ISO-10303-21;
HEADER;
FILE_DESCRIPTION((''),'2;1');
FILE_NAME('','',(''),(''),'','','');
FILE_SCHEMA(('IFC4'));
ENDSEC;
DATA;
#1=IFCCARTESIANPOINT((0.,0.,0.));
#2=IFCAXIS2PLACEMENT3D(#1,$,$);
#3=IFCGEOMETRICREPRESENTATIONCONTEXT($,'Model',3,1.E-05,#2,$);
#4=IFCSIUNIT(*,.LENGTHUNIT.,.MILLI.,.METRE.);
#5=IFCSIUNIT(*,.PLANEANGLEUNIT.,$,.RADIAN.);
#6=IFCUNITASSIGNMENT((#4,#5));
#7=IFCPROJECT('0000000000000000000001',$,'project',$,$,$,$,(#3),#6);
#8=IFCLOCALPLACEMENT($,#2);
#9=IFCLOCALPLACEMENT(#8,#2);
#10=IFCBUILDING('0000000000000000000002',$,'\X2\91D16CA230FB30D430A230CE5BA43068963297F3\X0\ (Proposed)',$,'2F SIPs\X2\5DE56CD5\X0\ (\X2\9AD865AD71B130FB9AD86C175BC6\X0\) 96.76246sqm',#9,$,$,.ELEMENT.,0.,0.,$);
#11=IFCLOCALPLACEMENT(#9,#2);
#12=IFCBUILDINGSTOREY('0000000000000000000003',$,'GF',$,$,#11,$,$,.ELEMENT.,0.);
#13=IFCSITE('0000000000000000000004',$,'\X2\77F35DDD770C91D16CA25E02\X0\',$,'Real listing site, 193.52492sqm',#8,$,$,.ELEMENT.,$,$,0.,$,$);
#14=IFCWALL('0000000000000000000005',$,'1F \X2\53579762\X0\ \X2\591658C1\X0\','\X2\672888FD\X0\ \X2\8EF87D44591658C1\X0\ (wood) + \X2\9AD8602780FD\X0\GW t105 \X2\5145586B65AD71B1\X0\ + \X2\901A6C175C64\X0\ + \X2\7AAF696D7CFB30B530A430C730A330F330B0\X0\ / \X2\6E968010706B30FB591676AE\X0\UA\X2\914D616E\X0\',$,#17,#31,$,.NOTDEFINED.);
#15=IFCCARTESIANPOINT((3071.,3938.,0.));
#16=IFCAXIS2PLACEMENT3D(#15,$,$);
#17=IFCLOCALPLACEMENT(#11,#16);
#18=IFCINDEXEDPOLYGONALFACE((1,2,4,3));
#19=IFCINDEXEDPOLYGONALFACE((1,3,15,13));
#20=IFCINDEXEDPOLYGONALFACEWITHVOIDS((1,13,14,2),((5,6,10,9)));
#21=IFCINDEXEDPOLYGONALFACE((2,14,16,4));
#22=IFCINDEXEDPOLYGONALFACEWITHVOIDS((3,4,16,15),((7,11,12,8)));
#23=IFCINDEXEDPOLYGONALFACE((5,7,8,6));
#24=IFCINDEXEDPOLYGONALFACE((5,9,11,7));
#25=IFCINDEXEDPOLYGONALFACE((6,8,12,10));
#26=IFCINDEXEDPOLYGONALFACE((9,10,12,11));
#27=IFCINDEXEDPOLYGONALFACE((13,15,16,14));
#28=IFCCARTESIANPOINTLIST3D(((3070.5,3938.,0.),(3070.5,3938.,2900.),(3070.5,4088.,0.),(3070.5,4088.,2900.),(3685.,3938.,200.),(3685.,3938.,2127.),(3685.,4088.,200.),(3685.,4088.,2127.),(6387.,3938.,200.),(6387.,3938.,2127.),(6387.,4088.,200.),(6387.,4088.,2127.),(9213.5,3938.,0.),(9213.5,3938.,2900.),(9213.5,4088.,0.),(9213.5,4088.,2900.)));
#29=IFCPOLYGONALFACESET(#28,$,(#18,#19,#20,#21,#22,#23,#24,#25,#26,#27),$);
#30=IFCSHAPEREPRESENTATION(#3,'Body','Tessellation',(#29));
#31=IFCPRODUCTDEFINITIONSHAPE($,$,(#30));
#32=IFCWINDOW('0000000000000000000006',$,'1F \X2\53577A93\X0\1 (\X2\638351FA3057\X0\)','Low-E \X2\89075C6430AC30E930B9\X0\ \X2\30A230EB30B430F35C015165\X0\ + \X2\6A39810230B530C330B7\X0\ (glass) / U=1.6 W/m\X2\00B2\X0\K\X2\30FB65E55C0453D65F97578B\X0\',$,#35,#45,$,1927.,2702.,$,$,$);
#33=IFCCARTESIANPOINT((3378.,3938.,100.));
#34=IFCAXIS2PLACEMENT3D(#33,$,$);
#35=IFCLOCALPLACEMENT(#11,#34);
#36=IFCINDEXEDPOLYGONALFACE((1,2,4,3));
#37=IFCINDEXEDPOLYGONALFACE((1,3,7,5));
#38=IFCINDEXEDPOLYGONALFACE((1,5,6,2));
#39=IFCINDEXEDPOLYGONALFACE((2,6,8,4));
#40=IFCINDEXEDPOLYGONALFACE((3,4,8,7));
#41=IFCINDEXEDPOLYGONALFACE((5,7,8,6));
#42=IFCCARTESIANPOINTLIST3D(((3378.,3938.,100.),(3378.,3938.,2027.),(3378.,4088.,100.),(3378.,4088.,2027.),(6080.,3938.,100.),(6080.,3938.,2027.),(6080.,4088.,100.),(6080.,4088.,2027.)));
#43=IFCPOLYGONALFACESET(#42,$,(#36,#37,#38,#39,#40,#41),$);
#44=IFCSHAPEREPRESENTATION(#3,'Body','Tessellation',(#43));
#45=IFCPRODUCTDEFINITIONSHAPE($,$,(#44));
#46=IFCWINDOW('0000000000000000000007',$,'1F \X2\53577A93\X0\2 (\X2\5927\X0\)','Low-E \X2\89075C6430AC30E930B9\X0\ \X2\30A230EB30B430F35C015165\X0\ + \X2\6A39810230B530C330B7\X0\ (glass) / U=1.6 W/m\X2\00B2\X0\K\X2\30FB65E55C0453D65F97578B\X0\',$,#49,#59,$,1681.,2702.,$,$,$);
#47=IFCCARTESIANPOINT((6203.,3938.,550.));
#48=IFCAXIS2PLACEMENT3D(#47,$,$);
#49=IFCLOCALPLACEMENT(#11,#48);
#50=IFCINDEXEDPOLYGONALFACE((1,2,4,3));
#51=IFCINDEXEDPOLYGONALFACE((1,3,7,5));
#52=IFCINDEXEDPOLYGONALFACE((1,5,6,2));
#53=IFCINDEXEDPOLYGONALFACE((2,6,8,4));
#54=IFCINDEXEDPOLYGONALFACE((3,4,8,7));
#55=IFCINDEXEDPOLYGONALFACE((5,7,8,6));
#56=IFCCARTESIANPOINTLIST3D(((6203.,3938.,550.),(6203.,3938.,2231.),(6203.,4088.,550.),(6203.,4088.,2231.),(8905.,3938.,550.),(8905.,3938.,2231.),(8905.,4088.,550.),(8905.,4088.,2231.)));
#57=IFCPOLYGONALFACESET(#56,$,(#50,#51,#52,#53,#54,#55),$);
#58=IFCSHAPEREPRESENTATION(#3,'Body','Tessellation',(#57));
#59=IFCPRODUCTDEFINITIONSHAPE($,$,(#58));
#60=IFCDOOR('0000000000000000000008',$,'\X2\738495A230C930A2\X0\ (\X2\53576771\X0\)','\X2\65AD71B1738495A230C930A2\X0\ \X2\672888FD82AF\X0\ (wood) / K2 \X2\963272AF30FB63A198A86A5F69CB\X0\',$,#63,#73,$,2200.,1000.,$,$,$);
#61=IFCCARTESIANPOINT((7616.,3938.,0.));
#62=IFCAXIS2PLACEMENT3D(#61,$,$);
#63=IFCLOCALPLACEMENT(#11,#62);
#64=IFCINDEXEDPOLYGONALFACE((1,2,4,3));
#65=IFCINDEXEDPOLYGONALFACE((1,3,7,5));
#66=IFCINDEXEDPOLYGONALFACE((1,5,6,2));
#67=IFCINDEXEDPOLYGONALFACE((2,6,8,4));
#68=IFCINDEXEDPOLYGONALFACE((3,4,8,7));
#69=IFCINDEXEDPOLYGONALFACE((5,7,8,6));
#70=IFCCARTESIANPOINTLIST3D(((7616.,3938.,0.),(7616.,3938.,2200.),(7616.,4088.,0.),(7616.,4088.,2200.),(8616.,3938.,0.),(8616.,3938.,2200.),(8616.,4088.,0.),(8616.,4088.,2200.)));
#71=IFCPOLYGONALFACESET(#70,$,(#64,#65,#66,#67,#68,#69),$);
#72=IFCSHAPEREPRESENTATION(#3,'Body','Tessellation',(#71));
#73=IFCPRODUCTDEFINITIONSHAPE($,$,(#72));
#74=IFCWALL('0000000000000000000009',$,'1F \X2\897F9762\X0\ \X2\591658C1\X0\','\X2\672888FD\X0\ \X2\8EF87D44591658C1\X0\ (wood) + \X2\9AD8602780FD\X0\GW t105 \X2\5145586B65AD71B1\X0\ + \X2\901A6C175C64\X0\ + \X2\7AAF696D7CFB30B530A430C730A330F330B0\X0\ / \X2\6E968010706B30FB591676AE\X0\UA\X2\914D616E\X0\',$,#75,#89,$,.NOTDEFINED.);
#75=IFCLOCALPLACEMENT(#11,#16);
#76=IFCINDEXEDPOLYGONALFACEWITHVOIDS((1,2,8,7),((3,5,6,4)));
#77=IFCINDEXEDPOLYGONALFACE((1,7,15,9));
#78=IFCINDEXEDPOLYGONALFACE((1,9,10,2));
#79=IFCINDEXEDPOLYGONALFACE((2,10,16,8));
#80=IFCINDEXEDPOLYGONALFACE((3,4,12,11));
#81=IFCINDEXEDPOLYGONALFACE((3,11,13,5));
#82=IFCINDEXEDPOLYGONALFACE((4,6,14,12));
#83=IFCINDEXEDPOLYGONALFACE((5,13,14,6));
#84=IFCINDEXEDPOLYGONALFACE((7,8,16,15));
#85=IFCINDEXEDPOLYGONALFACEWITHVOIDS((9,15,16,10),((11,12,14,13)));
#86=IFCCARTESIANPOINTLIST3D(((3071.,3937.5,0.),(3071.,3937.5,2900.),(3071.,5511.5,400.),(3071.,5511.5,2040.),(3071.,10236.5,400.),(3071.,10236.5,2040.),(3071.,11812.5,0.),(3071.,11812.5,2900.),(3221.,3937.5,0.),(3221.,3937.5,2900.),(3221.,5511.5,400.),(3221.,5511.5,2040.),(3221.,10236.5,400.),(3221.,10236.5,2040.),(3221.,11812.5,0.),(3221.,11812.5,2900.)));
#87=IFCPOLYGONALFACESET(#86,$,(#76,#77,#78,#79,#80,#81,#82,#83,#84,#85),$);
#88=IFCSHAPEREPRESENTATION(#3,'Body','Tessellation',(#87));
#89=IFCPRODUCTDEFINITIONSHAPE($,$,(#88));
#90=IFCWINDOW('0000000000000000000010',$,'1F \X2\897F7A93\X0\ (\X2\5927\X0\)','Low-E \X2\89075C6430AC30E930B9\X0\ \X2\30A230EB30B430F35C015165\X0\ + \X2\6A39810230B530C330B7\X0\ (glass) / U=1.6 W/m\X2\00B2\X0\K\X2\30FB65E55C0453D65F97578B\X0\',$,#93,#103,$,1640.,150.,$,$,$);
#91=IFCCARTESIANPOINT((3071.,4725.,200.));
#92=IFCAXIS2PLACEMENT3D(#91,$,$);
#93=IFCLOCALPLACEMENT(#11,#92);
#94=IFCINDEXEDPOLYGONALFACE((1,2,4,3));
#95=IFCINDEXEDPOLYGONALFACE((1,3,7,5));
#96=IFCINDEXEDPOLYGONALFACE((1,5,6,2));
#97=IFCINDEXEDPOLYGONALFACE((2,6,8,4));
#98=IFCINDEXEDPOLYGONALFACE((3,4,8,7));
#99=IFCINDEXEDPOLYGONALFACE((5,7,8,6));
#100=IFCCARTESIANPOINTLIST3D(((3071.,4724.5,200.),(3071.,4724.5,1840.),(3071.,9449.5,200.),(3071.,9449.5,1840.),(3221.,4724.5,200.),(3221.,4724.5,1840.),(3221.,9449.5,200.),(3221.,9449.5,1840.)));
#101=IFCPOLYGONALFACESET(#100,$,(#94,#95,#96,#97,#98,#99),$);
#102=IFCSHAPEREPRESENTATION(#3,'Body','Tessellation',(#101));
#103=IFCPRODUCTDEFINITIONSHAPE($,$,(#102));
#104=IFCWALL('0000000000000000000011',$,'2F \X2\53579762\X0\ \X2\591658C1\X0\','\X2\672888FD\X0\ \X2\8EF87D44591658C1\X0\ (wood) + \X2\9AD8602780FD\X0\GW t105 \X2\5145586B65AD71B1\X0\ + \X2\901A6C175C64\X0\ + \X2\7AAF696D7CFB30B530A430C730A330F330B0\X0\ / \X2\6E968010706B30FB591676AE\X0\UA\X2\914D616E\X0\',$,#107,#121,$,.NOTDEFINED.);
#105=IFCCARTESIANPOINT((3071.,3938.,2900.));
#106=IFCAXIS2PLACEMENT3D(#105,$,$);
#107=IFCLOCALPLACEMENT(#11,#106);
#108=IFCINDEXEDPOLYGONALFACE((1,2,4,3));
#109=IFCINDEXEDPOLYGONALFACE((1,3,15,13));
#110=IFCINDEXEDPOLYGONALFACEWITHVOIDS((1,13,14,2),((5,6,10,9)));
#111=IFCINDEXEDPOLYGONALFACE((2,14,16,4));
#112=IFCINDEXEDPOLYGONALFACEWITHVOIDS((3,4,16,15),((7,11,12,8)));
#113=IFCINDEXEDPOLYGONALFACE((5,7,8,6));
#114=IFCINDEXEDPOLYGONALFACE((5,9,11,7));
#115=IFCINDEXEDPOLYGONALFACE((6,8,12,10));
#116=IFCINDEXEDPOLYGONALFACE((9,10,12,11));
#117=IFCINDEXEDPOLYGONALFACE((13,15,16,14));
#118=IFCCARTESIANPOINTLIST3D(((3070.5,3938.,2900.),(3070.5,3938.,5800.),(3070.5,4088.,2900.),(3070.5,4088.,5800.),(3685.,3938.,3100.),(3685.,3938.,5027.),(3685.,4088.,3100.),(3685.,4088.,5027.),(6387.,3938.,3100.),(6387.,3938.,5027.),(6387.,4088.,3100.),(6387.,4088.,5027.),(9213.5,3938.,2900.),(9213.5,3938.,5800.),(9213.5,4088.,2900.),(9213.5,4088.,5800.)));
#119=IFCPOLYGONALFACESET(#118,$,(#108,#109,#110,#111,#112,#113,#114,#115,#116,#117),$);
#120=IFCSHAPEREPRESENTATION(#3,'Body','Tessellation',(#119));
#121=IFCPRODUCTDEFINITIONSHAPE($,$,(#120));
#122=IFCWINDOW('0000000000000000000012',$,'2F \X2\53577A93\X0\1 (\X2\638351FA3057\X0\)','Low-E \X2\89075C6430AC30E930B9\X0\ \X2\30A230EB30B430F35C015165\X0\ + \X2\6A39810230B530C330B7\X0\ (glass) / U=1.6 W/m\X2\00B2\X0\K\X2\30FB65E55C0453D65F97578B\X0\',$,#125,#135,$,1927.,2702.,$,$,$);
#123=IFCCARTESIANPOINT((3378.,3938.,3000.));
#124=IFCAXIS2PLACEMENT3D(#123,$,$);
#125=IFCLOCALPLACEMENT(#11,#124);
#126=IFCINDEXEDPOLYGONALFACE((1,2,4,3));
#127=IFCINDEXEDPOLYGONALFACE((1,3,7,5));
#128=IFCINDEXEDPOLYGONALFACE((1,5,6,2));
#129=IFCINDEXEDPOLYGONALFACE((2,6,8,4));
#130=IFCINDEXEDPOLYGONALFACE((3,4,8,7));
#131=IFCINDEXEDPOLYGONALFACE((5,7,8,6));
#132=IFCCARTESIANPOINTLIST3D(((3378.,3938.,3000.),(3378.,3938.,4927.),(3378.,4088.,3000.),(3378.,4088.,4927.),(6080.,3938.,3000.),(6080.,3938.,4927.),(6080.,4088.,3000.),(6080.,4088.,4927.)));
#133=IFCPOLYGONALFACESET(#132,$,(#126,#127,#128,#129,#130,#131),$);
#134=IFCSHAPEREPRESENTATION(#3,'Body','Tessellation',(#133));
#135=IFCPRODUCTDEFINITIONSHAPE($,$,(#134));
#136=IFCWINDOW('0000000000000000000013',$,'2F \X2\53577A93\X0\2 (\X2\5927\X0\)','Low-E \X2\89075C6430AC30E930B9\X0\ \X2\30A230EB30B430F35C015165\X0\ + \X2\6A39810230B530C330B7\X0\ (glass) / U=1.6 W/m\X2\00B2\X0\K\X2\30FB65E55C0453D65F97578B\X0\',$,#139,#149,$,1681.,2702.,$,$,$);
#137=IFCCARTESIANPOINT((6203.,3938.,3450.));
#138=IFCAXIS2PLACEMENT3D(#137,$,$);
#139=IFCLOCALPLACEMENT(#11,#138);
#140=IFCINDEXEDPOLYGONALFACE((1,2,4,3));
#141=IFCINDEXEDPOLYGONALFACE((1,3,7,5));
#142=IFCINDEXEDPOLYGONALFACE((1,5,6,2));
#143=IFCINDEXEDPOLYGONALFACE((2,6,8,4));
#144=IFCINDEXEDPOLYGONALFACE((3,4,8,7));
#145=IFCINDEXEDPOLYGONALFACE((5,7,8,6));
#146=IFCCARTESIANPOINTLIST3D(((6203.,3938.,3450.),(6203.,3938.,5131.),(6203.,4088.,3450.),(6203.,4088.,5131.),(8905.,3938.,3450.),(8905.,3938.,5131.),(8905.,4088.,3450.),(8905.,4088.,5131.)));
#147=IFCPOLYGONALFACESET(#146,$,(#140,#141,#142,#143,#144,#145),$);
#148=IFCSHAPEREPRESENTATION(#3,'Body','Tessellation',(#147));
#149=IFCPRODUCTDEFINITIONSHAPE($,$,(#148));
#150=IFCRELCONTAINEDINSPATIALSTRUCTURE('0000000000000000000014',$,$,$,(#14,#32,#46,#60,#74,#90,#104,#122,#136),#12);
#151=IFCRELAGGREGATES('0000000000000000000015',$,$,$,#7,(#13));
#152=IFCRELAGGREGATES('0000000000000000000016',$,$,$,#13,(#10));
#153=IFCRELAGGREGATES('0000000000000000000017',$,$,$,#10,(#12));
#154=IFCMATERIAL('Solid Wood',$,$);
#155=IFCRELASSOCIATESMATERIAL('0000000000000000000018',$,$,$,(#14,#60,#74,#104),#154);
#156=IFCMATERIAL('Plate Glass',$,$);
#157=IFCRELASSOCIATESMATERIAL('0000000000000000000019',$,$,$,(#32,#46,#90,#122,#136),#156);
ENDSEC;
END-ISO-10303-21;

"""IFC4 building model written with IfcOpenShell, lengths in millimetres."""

from ifc_helpers import new_model, si_unit, frame, frame_2d, origin, place, context, project, spatial, rectangle, extrude, material, element, fill, save


model = new_model("IFC4")

# Units and contexts
model_context = context("Model", 3, precision=1e-05, world=origin())
ifc_project = project(units=[si_unit("LENGTHUNIT", "METRE", prefix="MILLI"), si_unit("PLANEANGLEUNIT", "RADIAN")], contexts=[model_context])

# Site, building, storey
site_placement = place(None, origin())
site = spatial("IfcSite", under=ifc_project, at=site_placement, Name="石川県金沢市", ObjectType="Real listing site, 193.52492sqm", CompositionType="ELEMENT", RefElevation=0.0)
building_placement = place(site_placement, origin())
building = spatial("IfcBuilding", under=site, at=building_placement, Name="金沢・ピアノ室と防音 (Proposed)", ObjectType="2F SIPs工法 (高断熱・高気密) 96.76246sqm", CompositionType="ELEMENT", ElevationOfRefHeight=0.0, ElevationOfTerrain=0.0)
storey_placement = place(building_placement, origin())
storey = spatial("IfcBuildingStorey", under=building, at=storey_placement, Name="GF", CompositionType="ELEMENT", Elevation=0.0)

# Shared definitions
ifc_material_1 = material(Name="Solid Wood")

# Wall, openings, windows, door
wall_1_placement = place(storey_placement, frame((3071.0, 3938.0, 0.0)))
wall_1 = element("IfcWall", 1, at=wall_1_placement, inside=storey, material=ifc_material_1, Name="1F 南面 外壁", Description="木製 軸組外壁 (wood) + 高性能GW t105 充填断熱 + 通気層 + 窯業系サイディング / 準耐火・外皮UA配慮", PredefinedType="NOTDEFINED", context=model_context, shape_type="SweptSolid", body=[
    extrude(rectangle(XDim=6143.0, YDim=150.0, at=frame_2d((3071.0, 75.0))), frame((3071.0, 3938.0, 0.0)), (0.0, 0.0, 1.0), 2900.0),
])
opening_1_placement = place(storey_placement, frame((3378.0, 3938.0, 100.0)))
opening_1 = element("IfcOpeningElement", 2, at=opening_1_placement, cuts=wall_1, PredefinedType="NOTDEFINED", context=model_context, shape_type="SweptSolid", body=[
    extrude(rectangle(XDim=2702.0, YDim=150.0, at=frame_2d((1351.0, 75.0))), frame((3378.0, 3938.0, 100.0)), (0.0, 0.0, 1.0), 1927.0),
])
opening_2_placement = place(storey_placement, frame((6203.0, 3938.0, 550.0)))
opening_2 = element("IfcOpeningElement", 3, at=opening_2_placement, cuts=wall_1, PredefinedType="NOTDEFINED", context=model_context, shape_type="SweptSolid", body=[
    extrude(rectangle(XDim=2702.0, YDim=150.0, at=frame_2d((1351.0, 75.0))), frame((6203.0, 3938.0, 550.0)), (0.0, 0.0, 1.0), 1681.0),
])
opening_3_placement = place(storey_placement, frame((7616.0, 3938.0, 0.0)))
opening_3 = element("IfcOpeningElement", 4, at=opening_3_placement, cuts=wall_1, PredefinedType="NOTDEFINED", context=model_context, shape_type="SweptSolid", body=[
    extrude(rectangle(XDim=1000.0, YDim=150.0, at=frame_2d((500.0, 75.0))), frame((7616.0, 3938.0, 0.0)), (0.0, 0.0, 1.0), 2200.0),
])
ifc_material_2 = material(Name="Plate Glass")
window_1_placement = place(storey_placement, frame((3378.0, 3938.0, 100.0)))
window_1 = element("IfcWindow", 5, at=window_1_placement, inside=storey, material=ifc_material_2, Name="1F 南窓1 (掃出し)", Description="Low-E 複層ガラス アルゴン封入 + 樹脂サッシ (glass) / U=1.6 W/m²K・日射取得型", OverallHeight=1927.0, OverallWidth=2702.0, context=model_context, shape_type="SweptSolid", body=[
    extrude(rectangle(XDim=2702.0, YDim=150.0, at=frame_2d((1351.0, 75.0))), frame((3378.0, 3938.0, 100.0)), (0.0, 0.0, 1.0), 1927.0),
])
fill(opening_1, window_1)
window_2_placement = place(storey_placement, frame((6203.0, 3938.0, 550.0)))
window_2 = element("IfcWindow", 6, at=window_2_placement, inside=storey, material=ifc_material_2, Name="1F 南窓2 (大)", Description="Low-E 複層ガラス アルゴン封入 + 樹脂サッシ (glass) / U=1.6 W/m²K・日射取得型", OverallHeight=1681.0, OverallWidth=2702.0, context=model_context, shape_type="SweptSolid", body=[
    extrude(rectangle(XDim=2702.0, YDim=150.0, at=frame_2d((1351.0, 75.0))), frame((6203.0, 3938.0, 550.0)), (0.0, 0.0, 1.0), 1681.0),
])
fill(opening_2, window_2)
door_placement = place(storey_placement, frame((7616.0, 3938.0, 0.0)))
door = element("IfcDoor", 7, at=door_placement, inside=storey, material=ifc_material_1, Name="玄関ドア (南東)", Description="断熱玄関ドア 木製芯 (wood) / K2 防犯・採風機構", OverallHeight=2200.0, OverallWidth=1000.0, context=model_context, shape_type="SweptSolid", body=[
    extrude(rectangle(XDim=1000.0, YDim=150.0, at=frame_2d((500.0, 75.0))), frame((7616.0, 3938.0, 0.0)), (0.0, 0.0, 1.0), 2200.0),
])
fill(opening_3, door)

# Wall, opening, window
wall_2_placement = place(storey_placement, frame((3071.0, 3938.0, 0.0)))
wall_2 = element("IfcWall", 8, at=wall_2_placement, inside=storey, material=ifc_material_1, Name="1F 西面 外壁", Description="木製 軸組外壁 (wood) + 高性能GW t105 充填断熱 + 通気層 + 窯業系サイディング / 準耐火・外皮UA配慮", PredefinedType="NOTDEFINED", context=model_context, shape_type="SweptSolid", body=[
    extrude(rectangle(XDim=150.0, YDim=7875.0, at=frame_2d((75.0, 3937.0))), frame((3071.0, 3938.0, 0.0)), (0.0, 0.0, 1.0), 2900.0),
])
opening_4_placement = place(storey_placement, frame((3071.0, 4725.0, 200.0)))
opening_4 = element("IfcOpeningElement", 9, at=opening_4_placement, cuts=wall_2, PredefinedType="NOTDEFINED", context=model_context, shape_type="SweptSolid", body=[
    extrude(rectangle(XDim=150.0, YDim=4725.0, at=frame_2d((75.0, 2362.0))), frame((3071.0, 4725.0, 200.0)), (0.0, 0.0, 1.0), 1640.0),
])
window_3_placement = place(storey_placement, frame((3071.0, 4725.0, 200.0)))
window_3 = element("IfcWindow", 10, at=window_3_placement, inside=storey, material=ifc_material_2, Name="1F 西窓 (大)", Description="Low-E 複層ガラス アルゴン封入 + 樹脂サッシ (glass) / U=1.6 W/m²K・日射取得型", OverallHeight=1640.0, OverallWidth=150.0, context=model_context, shape_type="SweptSolid", body=[
    extrude(rectangle(XDim=150.0, YDim=4725.0, at=frame_2d((75.0, 2362.0))), frame((3071.0, 4725.0, 200.0)), (0.0, 0.0, 1.0), 1640.0),
])
fill(opening_4, window_3)

# Wall, openings, windows
wall_3_placement = place(storey_placement, frame((3071.0, 3938.0, 2900.0)))
wall_3 = element("IfcWall", 11, at=wall_3_placement, inside=storey, material=ifc_material_1, Name="2F 南面 外壁", Description="木製 軸組外壁 (wood) + 高性能GW t105 充填断熱 + 通気層 + 窯業系サイディング / 準耐火・外皮UA配慮", PredefinedType="NOTDEFINED", context=model_context, shape_type="SweptSolid", body=[
    extrude(rectangle(XDim=6143.0, YDim=150.0, at=frame_2d((3071.0, 75.0))), frame((3071.0, 3938.0, 2900.0)), (0.0, 0.0, 1.0), 2900.0),
])
opening_5_placement = place(storey_placement, frame((3378.0, 3938.0, 3000.0)))
opening_5 = element("IfcOpeningElement", 12, at=opening_5_placement, cuts=wall_3, PredefinedType="NOTDEFINED", context=model_context, shape_type="SweptSolid", body=[
    extrude(rectangle(XDim=2702.0, YDim=150.0, at=frame_2d((1351.0, 75.0))), frame((3378.0, 3938.0, 3000.0)), (0.0, 0.0, 1.0), 1927.0),
])
opening_6_placement = place(storey_placement, frame((6203.0, 3938.0, 3450.0)))
opening_6 = element("IfcOpeningElement", 13, at=opening_6_placement, cuts=wall_3, PredefinedType="NOTDEFINED", context=model_context, shape_type="SweptSolid", body=[
    extrude(rectangle(XDim=2702.0, YDim=150.0, at=frame_2d((1351.0, 75.0))), frame((6203.0, 3938.0, 3450.0)), (0.0, 0.0, 1.0), 1681.0),
])
window_4_placement = place(storey_placement, frame((3378.0, 3938.0, 3000.0)))
window_4 = element("IfcWindow", 14, at=window_4_placement, inside=storey, material=ifc_material_2, Name="2F 南窓1 (掃出し)", Description="Low-E 複層ガラス アルゴン封入 + 樹脂サッシ (glass) / U=1.6 W/m²K・日射取得型", OverallHeight=1927.0, OverallWidth=2702.0, context=model_context, shape_type="SweptSolid", body=[
    extrude(rectangle(XDim=2702.0, YDim=150.0, at=frame_2d((1351.0, 75.0))), frame((3378.0, 3938.0, 3000.0)), (0.0, 0.0, 1.0), 1927.0),
])
fill(opening_5, window_4)
window_5_placement = place(storey_placement, frame((6203.0, 3938.0, 3450.0)))
window_5 = element("IfcWindow", 15, at=window_5_placement, inside=storey, material=ifc_material_2, Name="2F 南窓2 (大)", Description="Low-E 複層ガラス アルゴン封入 + 樹脂サッシ (glass) / U=1.6 W/m²K・日射取得型", OverallHeight=1681.0, OverallWidth=2702.0, context=model_context, shape_type="SweptSolid", body=[
    extrude(rectangle(XDim=2702.0, YDim=150.0, at=frame_2d((1351.0, 75.0))), frame((6203.0, 3938.0, 3450.0)), (0.0, 0.0, 1.0), 1681.0),
])
fill(opening_6, window_5)

save(model, "model.ifc")
